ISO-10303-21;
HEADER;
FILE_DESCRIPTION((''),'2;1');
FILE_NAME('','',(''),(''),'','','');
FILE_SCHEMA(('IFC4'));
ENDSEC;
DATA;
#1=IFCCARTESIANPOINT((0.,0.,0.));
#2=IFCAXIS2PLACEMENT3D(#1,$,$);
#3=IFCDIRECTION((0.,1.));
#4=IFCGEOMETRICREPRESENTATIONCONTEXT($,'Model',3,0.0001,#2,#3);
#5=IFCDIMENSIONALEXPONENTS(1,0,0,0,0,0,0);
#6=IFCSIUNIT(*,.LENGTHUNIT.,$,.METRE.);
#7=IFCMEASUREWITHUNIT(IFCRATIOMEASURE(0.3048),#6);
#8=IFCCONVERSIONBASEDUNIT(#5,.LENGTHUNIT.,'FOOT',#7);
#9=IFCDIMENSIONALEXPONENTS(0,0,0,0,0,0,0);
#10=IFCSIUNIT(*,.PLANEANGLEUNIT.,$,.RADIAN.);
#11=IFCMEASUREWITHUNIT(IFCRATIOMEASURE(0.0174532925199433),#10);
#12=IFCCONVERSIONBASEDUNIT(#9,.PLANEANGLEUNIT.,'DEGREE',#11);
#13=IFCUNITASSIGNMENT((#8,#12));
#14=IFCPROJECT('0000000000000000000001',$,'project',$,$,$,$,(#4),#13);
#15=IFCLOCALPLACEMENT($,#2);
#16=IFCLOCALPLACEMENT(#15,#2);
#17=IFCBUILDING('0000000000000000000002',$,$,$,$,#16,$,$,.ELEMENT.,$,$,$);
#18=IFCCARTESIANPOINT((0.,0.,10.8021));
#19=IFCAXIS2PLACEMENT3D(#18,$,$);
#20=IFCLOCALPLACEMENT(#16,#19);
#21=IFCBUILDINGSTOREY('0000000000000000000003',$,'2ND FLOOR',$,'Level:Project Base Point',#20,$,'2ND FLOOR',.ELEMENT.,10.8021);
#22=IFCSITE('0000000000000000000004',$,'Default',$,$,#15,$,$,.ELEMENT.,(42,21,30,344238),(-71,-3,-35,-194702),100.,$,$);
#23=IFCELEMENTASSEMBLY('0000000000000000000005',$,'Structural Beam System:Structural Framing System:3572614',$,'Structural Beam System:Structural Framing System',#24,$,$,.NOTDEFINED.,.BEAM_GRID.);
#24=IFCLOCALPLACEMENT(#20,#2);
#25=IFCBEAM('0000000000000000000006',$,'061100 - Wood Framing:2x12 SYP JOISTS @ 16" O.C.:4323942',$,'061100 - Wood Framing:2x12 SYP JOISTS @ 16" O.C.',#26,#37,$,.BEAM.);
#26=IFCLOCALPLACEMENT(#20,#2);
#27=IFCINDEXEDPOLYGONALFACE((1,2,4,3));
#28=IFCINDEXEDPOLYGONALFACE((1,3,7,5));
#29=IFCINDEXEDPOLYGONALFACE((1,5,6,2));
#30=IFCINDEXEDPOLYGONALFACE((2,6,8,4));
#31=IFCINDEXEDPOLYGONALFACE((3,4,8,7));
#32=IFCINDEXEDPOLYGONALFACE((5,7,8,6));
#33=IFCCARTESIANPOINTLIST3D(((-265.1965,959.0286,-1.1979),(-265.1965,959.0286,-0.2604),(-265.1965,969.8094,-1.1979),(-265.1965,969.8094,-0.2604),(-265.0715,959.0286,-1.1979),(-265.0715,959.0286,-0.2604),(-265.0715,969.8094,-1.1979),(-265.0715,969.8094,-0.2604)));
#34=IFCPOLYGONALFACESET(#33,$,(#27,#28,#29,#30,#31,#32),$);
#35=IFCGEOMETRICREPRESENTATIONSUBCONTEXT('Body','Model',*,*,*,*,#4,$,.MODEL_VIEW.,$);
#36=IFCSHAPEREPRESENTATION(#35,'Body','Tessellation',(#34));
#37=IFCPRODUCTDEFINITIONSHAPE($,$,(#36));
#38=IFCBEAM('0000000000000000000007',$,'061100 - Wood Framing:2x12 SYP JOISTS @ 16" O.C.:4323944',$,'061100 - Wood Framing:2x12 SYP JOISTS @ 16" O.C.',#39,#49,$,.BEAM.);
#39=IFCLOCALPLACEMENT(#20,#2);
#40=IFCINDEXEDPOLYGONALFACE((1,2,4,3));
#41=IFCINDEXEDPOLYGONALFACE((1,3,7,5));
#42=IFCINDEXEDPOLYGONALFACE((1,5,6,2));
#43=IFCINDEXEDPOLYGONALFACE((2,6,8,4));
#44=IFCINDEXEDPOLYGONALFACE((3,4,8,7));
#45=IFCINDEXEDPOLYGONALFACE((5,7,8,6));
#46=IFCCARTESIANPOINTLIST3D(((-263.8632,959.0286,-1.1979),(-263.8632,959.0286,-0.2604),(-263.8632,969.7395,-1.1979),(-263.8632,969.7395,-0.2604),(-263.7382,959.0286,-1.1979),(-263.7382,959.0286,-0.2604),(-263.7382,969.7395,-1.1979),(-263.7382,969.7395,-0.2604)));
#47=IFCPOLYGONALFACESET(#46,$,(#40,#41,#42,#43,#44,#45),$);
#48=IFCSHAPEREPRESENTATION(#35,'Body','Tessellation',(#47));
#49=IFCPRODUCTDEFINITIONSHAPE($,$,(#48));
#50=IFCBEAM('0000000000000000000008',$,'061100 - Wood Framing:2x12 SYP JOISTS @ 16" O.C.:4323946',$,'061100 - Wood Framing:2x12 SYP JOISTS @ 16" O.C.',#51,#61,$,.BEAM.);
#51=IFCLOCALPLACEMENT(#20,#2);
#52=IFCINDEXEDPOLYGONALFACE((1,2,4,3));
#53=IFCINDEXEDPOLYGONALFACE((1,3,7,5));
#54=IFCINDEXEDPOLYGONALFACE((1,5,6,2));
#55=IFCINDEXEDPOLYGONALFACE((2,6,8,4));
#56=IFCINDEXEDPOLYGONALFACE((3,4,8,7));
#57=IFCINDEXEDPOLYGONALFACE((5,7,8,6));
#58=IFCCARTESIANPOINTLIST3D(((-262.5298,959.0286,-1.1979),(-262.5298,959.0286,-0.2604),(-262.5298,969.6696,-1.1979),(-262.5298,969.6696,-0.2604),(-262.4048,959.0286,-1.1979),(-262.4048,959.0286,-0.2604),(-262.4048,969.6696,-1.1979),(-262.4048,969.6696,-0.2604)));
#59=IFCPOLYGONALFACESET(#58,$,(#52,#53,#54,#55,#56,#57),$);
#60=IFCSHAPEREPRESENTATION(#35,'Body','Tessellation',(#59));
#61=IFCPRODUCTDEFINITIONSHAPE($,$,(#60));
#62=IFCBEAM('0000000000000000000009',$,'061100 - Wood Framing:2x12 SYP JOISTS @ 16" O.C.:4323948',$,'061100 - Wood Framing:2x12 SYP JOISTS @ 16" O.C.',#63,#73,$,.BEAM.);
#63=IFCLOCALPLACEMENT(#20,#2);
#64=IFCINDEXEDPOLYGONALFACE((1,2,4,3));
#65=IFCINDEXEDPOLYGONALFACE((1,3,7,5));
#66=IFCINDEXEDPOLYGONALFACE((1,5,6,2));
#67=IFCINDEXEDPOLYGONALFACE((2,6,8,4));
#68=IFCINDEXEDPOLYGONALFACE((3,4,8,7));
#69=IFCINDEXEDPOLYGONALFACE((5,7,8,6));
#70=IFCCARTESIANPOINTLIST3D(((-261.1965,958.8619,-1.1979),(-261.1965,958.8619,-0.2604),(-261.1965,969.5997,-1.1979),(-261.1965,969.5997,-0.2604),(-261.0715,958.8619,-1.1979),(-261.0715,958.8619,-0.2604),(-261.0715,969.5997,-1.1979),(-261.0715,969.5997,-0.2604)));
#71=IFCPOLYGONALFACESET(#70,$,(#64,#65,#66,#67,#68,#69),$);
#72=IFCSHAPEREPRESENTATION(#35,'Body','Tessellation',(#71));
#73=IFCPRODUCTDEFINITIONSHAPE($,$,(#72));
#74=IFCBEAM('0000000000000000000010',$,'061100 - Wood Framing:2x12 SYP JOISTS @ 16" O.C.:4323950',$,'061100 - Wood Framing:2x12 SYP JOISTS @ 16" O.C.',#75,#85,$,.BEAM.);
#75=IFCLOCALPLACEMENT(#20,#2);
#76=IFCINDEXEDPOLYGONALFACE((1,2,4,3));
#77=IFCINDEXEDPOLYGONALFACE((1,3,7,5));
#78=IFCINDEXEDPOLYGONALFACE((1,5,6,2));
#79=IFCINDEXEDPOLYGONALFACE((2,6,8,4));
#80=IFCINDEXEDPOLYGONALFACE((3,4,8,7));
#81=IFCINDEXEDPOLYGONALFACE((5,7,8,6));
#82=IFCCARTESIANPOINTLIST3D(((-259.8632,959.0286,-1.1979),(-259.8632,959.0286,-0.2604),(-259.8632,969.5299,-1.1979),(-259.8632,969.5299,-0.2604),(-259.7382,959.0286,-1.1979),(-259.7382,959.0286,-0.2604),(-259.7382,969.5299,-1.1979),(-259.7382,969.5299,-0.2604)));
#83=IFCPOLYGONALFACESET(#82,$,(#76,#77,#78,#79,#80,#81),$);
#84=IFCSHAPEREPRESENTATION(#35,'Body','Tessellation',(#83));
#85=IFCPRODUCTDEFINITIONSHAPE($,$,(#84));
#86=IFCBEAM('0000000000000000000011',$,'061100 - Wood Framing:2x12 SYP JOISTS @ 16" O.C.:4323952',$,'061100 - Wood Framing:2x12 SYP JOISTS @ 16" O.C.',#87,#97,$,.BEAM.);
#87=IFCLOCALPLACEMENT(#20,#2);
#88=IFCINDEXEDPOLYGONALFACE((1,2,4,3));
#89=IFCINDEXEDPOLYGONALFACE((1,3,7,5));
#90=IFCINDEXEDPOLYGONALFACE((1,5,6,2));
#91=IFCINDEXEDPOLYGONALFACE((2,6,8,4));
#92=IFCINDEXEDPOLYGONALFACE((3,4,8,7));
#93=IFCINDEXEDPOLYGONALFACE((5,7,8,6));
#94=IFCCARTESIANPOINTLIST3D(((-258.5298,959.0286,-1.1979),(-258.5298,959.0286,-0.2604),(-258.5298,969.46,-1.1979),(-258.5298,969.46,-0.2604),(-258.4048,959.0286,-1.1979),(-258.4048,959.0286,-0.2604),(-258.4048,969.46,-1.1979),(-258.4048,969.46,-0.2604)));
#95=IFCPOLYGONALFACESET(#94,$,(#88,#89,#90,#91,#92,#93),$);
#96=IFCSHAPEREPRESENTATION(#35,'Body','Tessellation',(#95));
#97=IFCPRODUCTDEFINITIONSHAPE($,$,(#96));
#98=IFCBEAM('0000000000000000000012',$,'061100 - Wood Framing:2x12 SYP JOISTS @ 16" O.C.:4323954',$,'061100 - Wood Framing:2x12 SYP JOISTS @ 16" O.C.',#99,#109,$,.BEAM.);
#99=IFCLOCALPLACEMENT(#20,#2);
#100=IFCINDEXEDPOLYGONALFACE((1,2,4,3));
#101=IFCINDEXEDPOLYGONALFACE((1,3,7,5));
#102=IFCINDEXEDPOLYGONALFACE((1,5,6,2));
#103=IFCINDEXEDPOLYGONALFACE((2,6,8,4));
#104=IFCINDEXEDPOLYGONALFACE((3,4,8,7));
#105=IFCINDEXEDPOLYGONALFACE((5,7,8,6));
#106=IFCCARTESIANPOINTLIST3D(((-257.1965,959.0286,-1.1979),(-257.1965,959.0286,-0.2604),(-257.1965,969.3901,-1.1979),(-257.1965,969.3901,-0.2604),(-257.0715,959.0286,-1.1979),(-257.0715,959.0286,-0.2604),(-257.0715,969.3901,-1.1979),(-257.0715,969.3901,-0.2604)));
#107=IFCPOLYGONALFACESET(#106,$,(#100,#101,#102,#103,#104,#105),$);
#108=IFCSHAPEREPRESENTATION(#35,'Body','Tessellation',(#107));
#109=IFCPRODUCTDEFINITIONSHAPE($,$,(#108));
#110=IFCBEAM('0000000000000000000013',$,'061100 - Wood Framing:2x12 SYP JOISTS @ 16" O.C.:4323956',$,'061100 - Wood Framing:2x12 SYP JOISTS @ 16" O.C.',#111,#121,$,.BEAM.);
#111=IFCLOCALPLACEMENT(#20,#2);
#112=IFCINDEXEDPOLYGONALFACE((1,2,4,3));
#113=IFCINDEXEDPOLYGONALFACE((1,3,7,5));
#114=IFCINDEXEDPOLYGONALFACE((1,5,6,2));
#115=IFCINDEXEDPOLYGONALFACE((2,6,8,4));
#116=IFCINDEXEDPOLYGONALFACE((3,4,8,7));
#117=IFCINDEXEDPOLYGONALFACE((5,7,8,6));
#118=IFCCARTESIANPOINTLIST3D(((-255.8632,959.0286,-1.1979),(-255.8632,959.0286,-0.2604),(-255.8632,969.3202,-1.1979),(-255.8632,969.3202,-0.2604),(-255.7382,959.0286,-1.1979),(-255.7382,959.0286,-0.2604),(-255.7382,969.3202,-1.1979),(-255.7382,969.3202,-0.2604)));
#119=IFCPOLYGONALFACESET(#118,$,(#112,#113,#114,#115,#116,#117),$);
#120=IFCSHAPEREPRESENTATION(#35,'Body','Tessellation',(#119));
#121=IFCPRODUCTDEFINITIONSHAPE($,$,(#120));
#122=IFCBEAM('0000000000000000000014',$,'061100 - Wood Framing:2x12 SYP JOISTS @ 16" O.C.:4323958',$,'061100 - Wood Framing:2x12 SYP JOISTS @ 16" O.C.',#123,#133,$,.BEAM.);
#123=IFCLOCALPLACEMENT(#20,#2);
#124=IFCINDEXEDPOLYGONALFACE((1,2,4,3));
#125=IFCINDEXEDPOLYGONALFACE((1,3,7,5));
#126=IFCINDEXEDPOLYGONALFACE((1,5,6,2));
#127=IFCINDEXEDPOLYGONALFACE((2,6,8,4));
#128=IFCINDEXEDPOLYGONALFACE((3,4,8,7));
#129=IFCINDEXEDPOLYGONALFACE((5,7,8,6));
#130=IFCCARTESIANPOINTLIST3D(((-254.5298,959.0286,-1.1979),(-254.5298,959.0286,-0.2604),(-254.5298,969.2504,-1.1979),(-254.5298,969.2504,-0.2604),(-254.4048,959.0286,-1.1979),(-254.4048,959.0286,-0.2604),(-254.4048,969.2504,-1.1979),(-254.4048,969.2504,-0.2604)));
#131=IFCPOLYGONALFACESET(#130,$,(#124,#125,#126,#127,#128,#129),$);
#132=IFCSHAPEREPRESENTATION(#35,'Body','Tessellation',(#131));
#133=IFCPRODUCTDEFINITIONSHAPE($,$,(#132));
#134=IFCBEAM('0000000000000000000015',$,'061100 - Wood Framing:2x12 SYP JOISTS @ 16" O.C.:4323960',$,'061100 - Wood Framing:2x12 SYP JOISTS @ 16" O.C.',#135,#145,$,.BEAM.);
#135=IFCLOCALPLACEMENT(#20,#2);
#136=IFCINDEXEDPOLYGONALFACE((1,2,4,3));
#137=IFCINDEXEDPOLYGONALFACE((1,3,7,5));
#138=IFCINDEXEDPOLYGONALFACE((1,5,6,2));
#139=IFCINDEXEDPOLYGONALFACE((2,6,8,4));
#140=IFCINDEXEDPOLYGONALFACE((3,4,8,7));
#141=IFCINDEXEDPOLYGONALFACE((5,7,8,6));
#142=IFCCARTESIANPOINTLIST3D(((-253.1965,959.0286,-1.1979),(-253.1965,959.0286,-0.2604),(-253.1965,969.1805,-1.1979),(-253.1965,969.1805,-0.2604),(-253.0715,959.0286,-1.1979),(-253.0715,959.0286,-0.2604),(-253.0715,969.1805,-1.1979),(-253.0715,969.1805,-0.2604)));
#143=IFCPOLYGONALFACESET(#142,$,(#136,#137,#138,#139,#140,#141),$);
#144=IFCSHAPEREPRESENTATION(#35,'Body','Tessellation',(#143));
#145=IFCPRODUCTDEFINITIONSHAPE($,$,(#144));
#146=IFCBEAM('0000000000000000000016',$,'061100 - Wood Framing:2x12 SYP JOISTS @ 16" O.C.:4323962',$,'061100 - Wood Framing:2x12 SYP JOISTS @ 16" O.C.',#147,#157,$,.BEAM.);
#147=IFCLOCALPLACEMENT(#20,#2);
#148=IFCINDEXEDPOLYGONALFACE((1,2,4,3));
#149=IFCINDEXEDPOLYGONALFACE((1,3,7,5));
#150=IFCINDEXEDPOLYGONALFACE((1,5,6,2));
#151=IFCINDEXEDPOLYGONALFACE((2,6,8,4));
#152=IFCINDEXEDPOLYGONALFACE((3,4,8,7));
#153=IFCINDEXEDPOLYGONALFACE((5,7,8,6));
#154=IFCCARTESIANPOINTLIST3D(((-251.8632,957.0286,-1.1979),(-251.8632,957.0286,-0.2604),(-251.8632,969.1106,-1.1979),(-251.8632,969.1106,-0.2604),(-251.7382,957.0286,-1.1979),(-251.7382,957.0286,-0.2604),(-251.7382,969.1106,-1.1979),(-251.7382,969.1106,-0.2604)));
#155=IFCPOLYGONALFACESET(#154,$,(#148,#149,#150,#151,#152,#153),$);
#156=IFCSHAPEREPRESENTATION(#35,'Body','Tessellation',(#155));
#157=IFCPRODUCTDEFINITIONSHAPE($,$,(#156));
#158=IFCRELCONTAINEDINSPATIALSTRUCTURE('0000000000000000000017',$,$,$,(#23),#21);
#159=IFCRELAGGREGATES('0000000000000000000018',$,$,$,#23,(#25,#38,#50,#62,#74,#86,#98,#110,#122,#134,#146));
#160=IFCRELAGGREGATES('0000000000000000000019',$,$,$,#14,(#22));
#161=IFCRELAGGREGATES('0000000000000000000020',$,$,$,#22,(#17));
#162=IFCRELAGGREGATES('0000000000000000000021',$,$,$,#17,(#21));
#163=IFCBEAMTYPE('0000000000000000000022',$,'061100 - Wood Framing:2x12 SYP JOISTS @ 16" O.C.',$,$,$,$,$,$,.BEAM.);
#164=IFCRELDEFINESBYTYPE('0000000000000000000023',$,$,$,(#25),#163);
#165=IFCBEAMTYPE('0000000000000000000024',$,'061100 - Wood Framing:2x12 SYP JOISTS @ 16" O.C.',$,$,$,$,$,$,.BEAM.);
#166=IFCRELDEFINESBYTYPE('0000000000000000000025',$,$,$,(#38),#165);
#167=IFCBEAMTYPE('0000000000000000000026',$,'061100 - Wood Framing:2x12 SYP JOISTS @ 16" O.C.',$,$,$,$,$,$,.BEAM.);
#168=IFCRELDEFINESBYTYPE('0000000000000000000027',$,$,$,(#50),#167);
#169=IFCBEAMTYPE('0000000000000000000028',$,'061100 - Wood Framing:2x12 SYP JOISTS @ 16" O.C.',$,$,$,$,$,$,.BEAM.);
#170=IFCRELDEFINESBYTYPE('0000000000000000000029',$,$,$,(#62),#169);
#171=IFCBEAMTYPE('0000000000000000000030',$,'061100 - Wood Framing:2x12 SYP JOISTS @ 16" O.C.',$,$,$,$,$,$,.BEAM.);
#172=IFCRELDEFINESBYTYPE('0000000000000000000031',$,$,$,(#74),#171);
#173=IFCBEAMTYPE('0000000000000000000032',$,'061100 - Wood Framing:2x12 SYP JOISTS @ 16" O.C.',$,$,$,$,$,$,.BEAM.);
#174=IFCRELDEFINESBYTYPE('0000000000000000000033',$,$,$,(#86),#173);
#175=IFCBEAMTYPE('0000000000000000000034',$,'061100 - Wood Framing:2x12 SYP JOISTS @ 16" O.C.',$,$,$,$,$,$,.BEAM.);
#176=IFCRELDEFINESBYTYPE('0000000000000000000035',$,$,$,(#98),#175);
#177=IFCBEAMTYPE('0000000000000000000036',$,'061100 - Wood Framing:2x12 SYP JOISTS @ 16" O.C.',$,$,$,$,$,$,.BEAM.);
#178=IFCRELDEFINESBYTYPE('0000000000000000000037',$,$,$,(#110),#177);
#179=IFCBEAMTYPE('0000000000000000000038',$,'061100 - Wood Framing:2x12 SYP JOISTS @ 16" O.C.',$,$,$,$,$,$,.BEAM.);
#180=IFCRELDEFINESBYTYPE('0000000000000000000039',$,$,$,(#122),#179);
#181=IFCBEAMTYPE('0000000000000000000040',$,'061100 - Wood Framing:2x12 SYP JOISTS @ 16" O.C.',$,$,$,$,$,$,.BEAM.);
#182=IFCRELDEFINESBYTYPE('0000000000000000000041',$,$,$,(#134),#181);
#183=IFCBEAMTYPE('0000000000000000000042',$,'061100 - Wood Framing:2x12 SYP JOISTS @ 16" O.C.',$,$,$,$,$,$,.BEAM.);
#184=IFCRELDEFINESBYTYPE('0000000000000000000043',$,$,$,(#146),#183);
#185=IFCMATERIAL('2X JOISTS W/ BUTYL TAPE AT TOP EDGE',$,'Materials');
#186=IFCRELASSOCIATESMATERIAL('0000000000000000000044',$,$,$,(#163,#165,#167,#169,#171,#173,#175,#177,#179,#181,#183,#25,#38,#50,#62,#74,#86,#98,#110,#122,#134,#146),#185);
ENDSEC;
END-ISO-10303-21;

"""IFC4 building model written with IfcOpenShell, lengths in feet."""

from ifc_helpers import new_model, entity, si_unit, converted_unit, direction, frame, origin, origin_2d_with_axis, place, context, subcontext, project, spatial, rectangle, extrude, source, transform, mapped, material, material_profile, profile_set, profile_usage, type_object, type_shapes, element, aggregate, save


model = new_model("IFC4")

# Units and contexts
model_context = context("Model", 3, precision=0.0001, world=origin(), true_north=direction((0.0, 1.0)))
body_context = subcontext(model_context, "Body", "Model", "MODEL_VIEW")
ifc_project = project(units=[converted_unit("LENGTHUNIT", "FOOT", entity("IfcRatioMeasure", 0.3048), si_unit("LENGTHUNIT", "METRE"), dimensions=[1, 0, 0, 0, 0, 0, 0]), converted_unit("PLANEANGLEUNIT", "DEGREE", entity("IfcRatioMeasure", 0.0174532925199433), si_unit("PLANEANGLEUNIT", "RADIAN"), dimensions=[0, 0, 0, 0, 0, 0, 0])], contexts=[model_context])

# Site, building, storey
site_placement = place(None, origin())
site = spatial("IfcSite", under=ifc_project, at=site_placement, Name="Default", CompositionType="ELEMENT", RefLatitude=(42, 21, 30, 344238), RefLongitude=(-71, -3, -35, -194702), RefElevation=100.0)
building_placement = place(site_placement, origin())
building = spatial("IfcBuilding", under=site, at=building_placement, CompositionType="ELEMENT")
storey_placement = place(building_placement, frame((0.0, 0.0, 10.8021)))
storey = spatial("IfcBuildingStorey", under=building, at=storey_placement, Name="2ND FLOOR", ObjectType="Level:Project Base Point", LongName="2ND FLOOR", CompositionType="ELEMENT", Elevation=10.8021)

# Element assembly, beams
assembly_placement = place(storey_placement, origin())
assembly = element("IfcElementAssembly", 1, at=assembly_placement, inside=storey, Name="Structural Beam System:Structural Framing System:3572614", ObjectType="Structural Beam System:Structural Framing System", AssemblyPlace="NOTDEFINED", PredefinedType="BEAM_GRID")
ifc_material_1 = material(Name="2X JOISTS W/ BUTYL TAPE AT TOP EDGE", Category="Materials")
ifc_material_profile = material_profile(ifc_material_1, rectangle(XDim=0.9375, YDim=0.125, at=origin_2d_with_axis()), Name="2x12 SYP JOISTS @ 16\" O.C.")
ifc_profile_set = profile_set([ifc_material_profile], Name="2x12 SYP JOISTS @ 16\" O.C.")
ifc_profile_usage_1 = profile_usage(ifc_profile_set, cardinal=8)
beam_type_1 = type_object("IfcBeamType", Name="061100 - Wood Framing:2x12 SYP JOISTS @ 16\" O.C.", PredefinedType="BEAM", material=ifc_profile_set)
shared_shape_1 = source(origin(), body_context, "Body", "SweptSolid", [
    extrude(rectangle(XDim=0.9375, YDim=0.125, at=origin_2d_with_axis()), frame((-5.3904, 0.0, 0.0), z_axis=(1.0, 0.0, 0.0), x_axis=(0.0, 0.0, -1.0)), (0.0, 0.0, 1.0), 10.7808),
])
type_shapes(beam_type_1, [shared_shape_1])
beam_1_placement = place(assembly_placement, frame((-265.134, 964.419, -0.7292), z_axis=(0.0, 0.0, 1.0), x_axis=(0.0, 1.0, 0.0)))
beam_1 = element("IfcBeam", 2, at=beam_1_placement, type_object=beam_type_1, material=ifc_profile_usage_1, Name="061100 - Wood Framing:2x12 SYP JOISTS @ 16\" O.C.:4323942", ObjectType="061100 - Wood Framing:2x12 SYP JOISTS @ 16\" O.C.", PredefinedType="BEAM", context=body_context, shape_type="MappedRepresentation", body=[
    mapped(shared_shape_1, transform((0.0, 0.0, 0.0), scale=1.0)),
])
ifc_profile_usage_2 = profile_usage(ifc_profile_set, cardinal=8)
beam_type_2 = type_object("IfcBeamType", Name="061100 - Wood Framing:2x12 SYP JOISTS @ 16\" O.C.", PredefinedType="BEAM", material=ifc_profile_set)
shared_shape_2 = source(origin(), body_context, "Body", "SweptSolid", [
    extrude(rectangle(XDim=0.9375, YDim=0.125, at=origin_2d_with_axis()), frame((-5.3554, 0.0, 0.0), z_axis=(1.0, 0.0, 0.0), x_axis=(0.0, 0.0, -1.0)), (0.0, 0.0, 1.0), 10.7109),
])
type_shapes(beam_type_2, [shared_shape_2])
beam_2_placement = place(assembly_placement, frame((-263.8007, 964.384, -0.7292), z_axis=(0.0, 0.0, 1.0), x_axis=(0.0, 1.0, 0.0)))
beam_2 = element("IfcBeam", 3, at=beam_2_placement, type_object=beam_type_2, material=ifc_profile_usage_2, Name="061100 - Wood Framing:2x12 SYP JOISTS @ 16\" O.C.:4323944", ObjectType="061100 - Wood Framing:2x12 SYP JOISTS @ 16\" O.C.", PredefinedType="BEAM", context=body_context, shape_type="MappedRepresentation", body=[
    mapped(shared_shape_2, transform((0.0, 0.0, 0.0), scale=1.0)),
])
ifc_profile_usage_3 = profile_usage(ifc_profile_set, cardinal=8)
beam_type_3 = type_object("IfcBeamType", Name="061100 - Wood Framing:2x12 SYP JOISTS @ 16\" O.C.", PredefinedType="BEAM", material=ifc_profile_set)
shared_shape_3 = source(origin(), body_context, "Body", "SweptSolid", [
    extrude(rectangle(XDim=0.9375, YDim=0.125, at=origin_2d_with_axis()), frame((-5.3205, 0.0, 0.0), z_axis=(1.0, 0.0, 0.0), x_axis=(0.0, 0.0, -1.0)), (0.0, 0.0, 1.0), 10.641),
])
type_shapes(beam_type_3, [shared_shape_3])
beam_3_placement = place(assembly_placement, frame((-262.4673, 964.3491, -0.7292), z_axis=(0.0, 0.0, 1.0), x_axis=(0.0, 1.0, 0.0)))
beam_3 = element("IfcBeam", 4, at=beam_3_placement, type_object=beam_type_3, material=ifc_profile_usage_3, Name="061100 - Wood Framing:2x12 SYP JOISTS @ 16\" O.C.:4323946", ObjectType="061100 - Wood Framing:2x12 SYP JOISTS @ 16\" O.C.", PredefinedType="BEAM", context=body_context, shape_type="MappedRepresentation", body=[
    mapped(shared_shape_3, transform((0.0, 0.0, 0.0), scale=1.0)),
])
ifc_profile_usage_4 = profile_usage(ifc_profile_set, cardinal=8)
beam_type_4 = type_object("IfcBeamType", Name="061100 - Wood Framing:2x12 SYP JOISTS @ 16\" O.C.", PredefinedType="BEAM", material=ifc_profile_set)
shared_shape_4 = source(origin(), body_context, "Body", "SweptSolid", [
    extrude(rectangle(XDim=0.9375, YDim=0.125, at=origin_2d_with_axis()), frame((-5.2543, 0.0, 0.0), z_axis=(1.0, 0.0, 0.0), x_axis=(0.0, 0.0, -1.0)), (0.0, 0.0, 1.0), 10.7378),
])
type_shapes(beam_type_4, [shared_shape_4])
beam_4_placement = place(assembly_placement, frame((-261.134, 964.1163, -0.7292), z_axis=(0.0, 0.0, 1.0), x_axis=(0.0, 1.0, 0.0)))
beam_4 = element("IfcBeam", 5, at=beam_4_placement, type_object=beam_type_4, material=ifc_profile_usage_4, Name="061100 - Wood Framing:2x12 SYP JOISTS @ 16\" O.C.:4323948", ObjectType="061100 - Wood Framing:2x12 SYP JOISTS @ 16\" O.C.", PredefinedType="BEAM", context=body_context, shape_type="MappedRepresentation", body=[
    mapped(shared_shape_4, transform((0.0, 0.0, 0.0), scale=1.0)),
])
ifc_profile_usage_5 = profile_usage(ifc_profile_set, cardinal=8)
beam_type_5 = type_object("IfcBeamType", Name="061100 - Wood Framing:2x12 SYP JOISTS @ 16\" O.C.", PredefinedType="BEAM", material=ifc_profile_set)
shared_shape_5 = source(origin(), body_context, "Body", "SweptSolid", [
    extrude(rectangle(XDim=0.9375, YDim=0.125, at=origin_2d_with_axis()), frame((-5.2506, 0.0, 0.0), z_axis=(1.0, 0.0, 0.0), x_axis=(0.0, 0.0, -1.0)), (0.0, 0.0, 1.0), 10.5013),
])
type_shapes(beam_type_5, [shared_shape_5])
beam_5_placement = place(assembly_placement, frame((-259.8007, 964.2792, -0.7292), z_axis=(0.0, 0.0, 1.0), x_axis=(0.0, 1.0, 0.0)))
beam_5 = element("IfcBeam", 6, at=beam_5_placement, type_object=beam_type_5, material=ifc_profile_usage_5, Name="061100 - Wood Framing:2x12 SYP JOISTS @ 16\" O.C.:4323950", ObjectType="061100 - Wood Framing:2x12 SYP JOISTS @ 16\" O.C.", PredefinedType="BEAM", context=body_context, shape_type="MappedRepresentation", body=[
    mapped(shared_shape_5, transform((0.0, 0.0, 0.0), scale=1.0)),
])
ifc_profile_usage_6 = profile_usage(ifc_profile_set, cardinal=8)
beam_type_6 = type_object("IfcBeamType", Name="061100 - Wood Framing:2x12 SYP JOISTS @ 16\" O.C.", PredefinedType="BEAM", material=ifc_profile_set)
shared_shape_6 = source(origin(), body_context, "Body", "SweptSolid", [
    extrude(rectangle(XDim=0.9375, YDim=0.125, at=origin_2d_with_axis()), frame((-5.2157, 0.0, 0.0), z_axis=(1.0, 0.0, 0.0), x_axis=(0.0, 0.0, -1.0)), (0.0, 0.0, 1.0), 10.4314),
])
type_shapes(beam_type_6, [shared_shape_6])
beam_6_placement = place(assembly_placement, frame((-258.4673, 964.2443, -0.7292), z_axis=(0.0, 0.0, 1.0), x_axis=(0.0, 1.0, 0.0)))
beam_6 = element("IfcBeam", 7, at=beam_6_placement, type_object=beam_type_6, material=ifc_profile_usage_6, Name="061100 - Wood Framing:2x12 SYP JOISTS @ 16\" O.C.:4323952", ObjectType="061100 - Wood Framing:2x12 SYP JOISTS @ 16\" O.C.", PredefinedType="BEAM", context=body_context, shape_type="MappedRepresentation", body=[
    mapped(shared_shape_6, transform((0.0, 0.0, 0.0), scale=1.0)),
])
ifc_profile_usage_7 = profile_usage(ifc_profile_set, cardinal=8)
beam_type_7 = type_object("IfcBeamType", Name="061100 - Wood Framing:2x12 SYP JOISTS @ 16\" O.C.", PredefinedType="BEAM", material=ifc_profile_set)
shared_shape_7 = source(origin(), body_context, "Body", "SweptSolid", [
    extrude(rectangle(XDim=0.9375, YDim=0.125, at=origin_2d_with_axis()), frame((-5.1808, 0.0, 0.0), z_axis=(1.0, 0.0, 0.0), x_axis=(0.0, 0.0, -1.0)), (0.0, 0.0, 1.0), 10.3615),
])
type_shapes(beam_type_7, [shared_shape_7])
beam_7_placement = place(assembly_placement, frame((-257.134, 964.2094, -0.7292), z_axis=(0.0, 0.0, 1.0), x_axis=(0.0, 1.0, 0.0)))
beam_7 = element("IfcBeam", 8, at=beam_7_placement, type_object=beam_type_7, material=ifc_profile_usage_7, Name="061100 - Wood Framing:2x12 SYP JOISTS @ 16\" O.C.:4323954", ObjectType="061100 - Wood Framing:2x12 SYP JOISTS @ 16\" O.C.", PredefinedType="BEAM", context=body_context, shape_type="MappedRepresentation", body=[
    mapped(shared_shape_7, transform((0.0, 0.0, 0.0), scale=1.0)),
])
ifc_profile_usage_8 = profile_usage(ifc_profile_set, cardinal=8)
beam_type_8 = type_object("IfcBeamType", Name="061100 - Wood Framing:2x12 SYP JOISTS @ 16\" O.C.", PredefinedType="BEAM", material=ifc_profile_set)
shared_shape_8 = source(origin(), body_context, "Body", "SweptSolid", [
    extrude(rectangle(XDim=0.9375, YDim=0.125, at=origin_2d_with_axis()), frame((-5.1458, 0.0, 0.0), z_axis=(1.0, 0.0, 0.0), x_axis=(0.0, 0.0, -1.0)), (0.0, 0.0, 1.0), 10.2916),
])
type_shapes(beam_type_8, [shared_shape_8])
beam_8_placement = place(assembly_placement, frame((-255.8007, 964.1744, -0.7292), z_axis=(0.0, 0.0, 1.0), x_axis=(0.0, 1.0, 0.0)))
beam_8 = element("IfcBeam", 9, at=beam_8_placement, type_object=beam_type_8, material=ifc_profile_usage_8, Name="061100 - Wood Framing:2x12 SYP JOISTS @ 16\" O.C.:4323956", ObjectType="061100 - Wood Framing:2x12 SYP JOISTS @ 16\" O.C.", PredefinedType="BEAM", context=body_context, shape_type="MappedRepresentation", body=[
    mapped(shared_shape_8, transform((0.0, 0.0, 0.0), scale=1.0)),
])
ifc_profile_usage_9 = profile_usage(ifc_profile_set, cardinal=8)
beam_type_9 = type_object("IfcBeamType", Name="061100 - Wood Framing:2x12 SYP JOISTS @ 16\" O.C.", PredefinedType="BEAM", material=ifc_profile_set)
shared_shape_9 = source(origin(), body_context, "Body", "SweptSolid", [
    extrude(rectangle(XDim=0.9375, YDim=0.125, at=origin_2d_with_axis()), frame((-5.1109, 0.0, 0.0), z_axis=(1.0, 0.0, 0.0), x_axis=(0.0, 0.0, -1.0)), (0.0, 0.0, 1.0), 10.2217),
])
type_shapes(beam_type_9, [shared_shape_9])
beam_9_placement = place(assembly_placement, frame((-254.4673, 964.1395, -0.7292), z_axis=(0.0, 0.0, 1.0), x_axis=(0.0, 1.0, 0.0)))
beam_9 = element("IfcBeam", 10, at=beam_9_placement, type_object=beam_type_9, material=ifc_profile_usage_9, Name="061100 - Wood Framing:2x12 SYP JOISTS @ 16\" O.C.:4323958", ObjectType="061100 - Wood Framing:2x12 SYP JOISTS @ 16\" O.C.", PredefinedType="BEAM", context=body_context, shape_type="MappedRepresentation", body=[
    mapped(shared_shape_9, transform((0.0, 0.0, 0.0), scale=1.0)),
])
ifc_profile_usage_10 = profile_usage(ifc_profile_set, cardinal=8)
beam_type_10 = type_object("IfcBeamType", Name="061100 - Wood Framing:2x12 SYP JOISTS @ 16\" O.C.", PredefinedType="BEAM", material=ifc_profile_set)
shared_shape_10 = source(origin(), body_context, "Body", "SweptSolid", [
    extrude(rectangle(XDim=0.9375, YDim=0.125, at=origin_2d_with_axis()), frame((-5.0759, 0.0, 0.0), z_axis=(1.0, 0.0, 0.0), x_axis=(0.0, 0.0, -1.0)), (0.0, 0.0, 1.0), 10.1519),
])
type_shapes(beam_type_10, [shared_shape_10])
beam_10_placement = place(assembly_placement, frame((-253.134, 964.1045, -0.7292), z_axis=(0.0, 0.0, 1.0), x_axis=(0.0, 1.0, 0.0)))
beam_10 = element("IfcBeam", 11, at=beam_10_placement, type_object=beam_type_10, material=ifc_profile_usage_10, Name="061100 - Wood Framing:2x12 SYP JOISTS @ 16\" O.C.:4323960", ObjectType="061100 - Wood Framing:2x12 SYP JOISTS @ 16\" O.C.", PredefinedType="BEAM", context=body_context, shape_type="MappedRepresentation", body=[
    mapped(shared_shape_10, transform((0.0, 0.0, 0.0), scale=1.0)),
])
ifc_profile_usage_11 = profile_usage(ifc_profile_set, cardinal=8)
beam_type_11 = type_object("IfcBeamType", Name="061100 - Wood Framing:2x12 SYP JOISTS @ 16\" O.C.", PredefinedType="BEAM", material=ifc_profile_set)
shared_shape_11 = source(origin(), body_context, "Body", "SweptSolid", [
    extrude(rectangle(XDim=0.9375, YDim=0.125, at=origin_2d_with_axis()), frame((-6.041, 0.0, 0.0), z_axis=(1.0, 0.0, 0.0), x_axis=(0.0, 0.0, -1.0)), (0.0, 0.0, 1.0), 12.082),
])
type_shapes(beam_type_11, [shared_shape_11])
beam_11_placement = place(assembly_placement, frame((-251.8007, 963.0696, -0.7292), z_axis=(0.0, 0.0, 1.0), x_axis=(0.0, 1.0, 0.0)))
beam_11 = element("IfcBeam", 12, at=beam_11_placement, type_object=beam_type_11, material=ifc_profile_usage_11, Name="061100 - Wood Framing:2x12 SYP JOISTS @ 16\" O.C.:4323962", ObjectType="061100 - Wood Framing:2x12 SYP JOISTS @ 16\" O.C.", PredefinedType="BEAM", context=body_context, shape_type="MappedRepresentation", body=[
    mapped(shared_shape_11, transform((0.0, 0.0, 0.0), scale=1.0)),
])
aggregate(assembly, [beam_1, beam_2, beam_3, beam_4, beam_5, beam_6, beam_7, beam_8, beam_9, beam_10, beam_11])

save(model, "model.ifc")
